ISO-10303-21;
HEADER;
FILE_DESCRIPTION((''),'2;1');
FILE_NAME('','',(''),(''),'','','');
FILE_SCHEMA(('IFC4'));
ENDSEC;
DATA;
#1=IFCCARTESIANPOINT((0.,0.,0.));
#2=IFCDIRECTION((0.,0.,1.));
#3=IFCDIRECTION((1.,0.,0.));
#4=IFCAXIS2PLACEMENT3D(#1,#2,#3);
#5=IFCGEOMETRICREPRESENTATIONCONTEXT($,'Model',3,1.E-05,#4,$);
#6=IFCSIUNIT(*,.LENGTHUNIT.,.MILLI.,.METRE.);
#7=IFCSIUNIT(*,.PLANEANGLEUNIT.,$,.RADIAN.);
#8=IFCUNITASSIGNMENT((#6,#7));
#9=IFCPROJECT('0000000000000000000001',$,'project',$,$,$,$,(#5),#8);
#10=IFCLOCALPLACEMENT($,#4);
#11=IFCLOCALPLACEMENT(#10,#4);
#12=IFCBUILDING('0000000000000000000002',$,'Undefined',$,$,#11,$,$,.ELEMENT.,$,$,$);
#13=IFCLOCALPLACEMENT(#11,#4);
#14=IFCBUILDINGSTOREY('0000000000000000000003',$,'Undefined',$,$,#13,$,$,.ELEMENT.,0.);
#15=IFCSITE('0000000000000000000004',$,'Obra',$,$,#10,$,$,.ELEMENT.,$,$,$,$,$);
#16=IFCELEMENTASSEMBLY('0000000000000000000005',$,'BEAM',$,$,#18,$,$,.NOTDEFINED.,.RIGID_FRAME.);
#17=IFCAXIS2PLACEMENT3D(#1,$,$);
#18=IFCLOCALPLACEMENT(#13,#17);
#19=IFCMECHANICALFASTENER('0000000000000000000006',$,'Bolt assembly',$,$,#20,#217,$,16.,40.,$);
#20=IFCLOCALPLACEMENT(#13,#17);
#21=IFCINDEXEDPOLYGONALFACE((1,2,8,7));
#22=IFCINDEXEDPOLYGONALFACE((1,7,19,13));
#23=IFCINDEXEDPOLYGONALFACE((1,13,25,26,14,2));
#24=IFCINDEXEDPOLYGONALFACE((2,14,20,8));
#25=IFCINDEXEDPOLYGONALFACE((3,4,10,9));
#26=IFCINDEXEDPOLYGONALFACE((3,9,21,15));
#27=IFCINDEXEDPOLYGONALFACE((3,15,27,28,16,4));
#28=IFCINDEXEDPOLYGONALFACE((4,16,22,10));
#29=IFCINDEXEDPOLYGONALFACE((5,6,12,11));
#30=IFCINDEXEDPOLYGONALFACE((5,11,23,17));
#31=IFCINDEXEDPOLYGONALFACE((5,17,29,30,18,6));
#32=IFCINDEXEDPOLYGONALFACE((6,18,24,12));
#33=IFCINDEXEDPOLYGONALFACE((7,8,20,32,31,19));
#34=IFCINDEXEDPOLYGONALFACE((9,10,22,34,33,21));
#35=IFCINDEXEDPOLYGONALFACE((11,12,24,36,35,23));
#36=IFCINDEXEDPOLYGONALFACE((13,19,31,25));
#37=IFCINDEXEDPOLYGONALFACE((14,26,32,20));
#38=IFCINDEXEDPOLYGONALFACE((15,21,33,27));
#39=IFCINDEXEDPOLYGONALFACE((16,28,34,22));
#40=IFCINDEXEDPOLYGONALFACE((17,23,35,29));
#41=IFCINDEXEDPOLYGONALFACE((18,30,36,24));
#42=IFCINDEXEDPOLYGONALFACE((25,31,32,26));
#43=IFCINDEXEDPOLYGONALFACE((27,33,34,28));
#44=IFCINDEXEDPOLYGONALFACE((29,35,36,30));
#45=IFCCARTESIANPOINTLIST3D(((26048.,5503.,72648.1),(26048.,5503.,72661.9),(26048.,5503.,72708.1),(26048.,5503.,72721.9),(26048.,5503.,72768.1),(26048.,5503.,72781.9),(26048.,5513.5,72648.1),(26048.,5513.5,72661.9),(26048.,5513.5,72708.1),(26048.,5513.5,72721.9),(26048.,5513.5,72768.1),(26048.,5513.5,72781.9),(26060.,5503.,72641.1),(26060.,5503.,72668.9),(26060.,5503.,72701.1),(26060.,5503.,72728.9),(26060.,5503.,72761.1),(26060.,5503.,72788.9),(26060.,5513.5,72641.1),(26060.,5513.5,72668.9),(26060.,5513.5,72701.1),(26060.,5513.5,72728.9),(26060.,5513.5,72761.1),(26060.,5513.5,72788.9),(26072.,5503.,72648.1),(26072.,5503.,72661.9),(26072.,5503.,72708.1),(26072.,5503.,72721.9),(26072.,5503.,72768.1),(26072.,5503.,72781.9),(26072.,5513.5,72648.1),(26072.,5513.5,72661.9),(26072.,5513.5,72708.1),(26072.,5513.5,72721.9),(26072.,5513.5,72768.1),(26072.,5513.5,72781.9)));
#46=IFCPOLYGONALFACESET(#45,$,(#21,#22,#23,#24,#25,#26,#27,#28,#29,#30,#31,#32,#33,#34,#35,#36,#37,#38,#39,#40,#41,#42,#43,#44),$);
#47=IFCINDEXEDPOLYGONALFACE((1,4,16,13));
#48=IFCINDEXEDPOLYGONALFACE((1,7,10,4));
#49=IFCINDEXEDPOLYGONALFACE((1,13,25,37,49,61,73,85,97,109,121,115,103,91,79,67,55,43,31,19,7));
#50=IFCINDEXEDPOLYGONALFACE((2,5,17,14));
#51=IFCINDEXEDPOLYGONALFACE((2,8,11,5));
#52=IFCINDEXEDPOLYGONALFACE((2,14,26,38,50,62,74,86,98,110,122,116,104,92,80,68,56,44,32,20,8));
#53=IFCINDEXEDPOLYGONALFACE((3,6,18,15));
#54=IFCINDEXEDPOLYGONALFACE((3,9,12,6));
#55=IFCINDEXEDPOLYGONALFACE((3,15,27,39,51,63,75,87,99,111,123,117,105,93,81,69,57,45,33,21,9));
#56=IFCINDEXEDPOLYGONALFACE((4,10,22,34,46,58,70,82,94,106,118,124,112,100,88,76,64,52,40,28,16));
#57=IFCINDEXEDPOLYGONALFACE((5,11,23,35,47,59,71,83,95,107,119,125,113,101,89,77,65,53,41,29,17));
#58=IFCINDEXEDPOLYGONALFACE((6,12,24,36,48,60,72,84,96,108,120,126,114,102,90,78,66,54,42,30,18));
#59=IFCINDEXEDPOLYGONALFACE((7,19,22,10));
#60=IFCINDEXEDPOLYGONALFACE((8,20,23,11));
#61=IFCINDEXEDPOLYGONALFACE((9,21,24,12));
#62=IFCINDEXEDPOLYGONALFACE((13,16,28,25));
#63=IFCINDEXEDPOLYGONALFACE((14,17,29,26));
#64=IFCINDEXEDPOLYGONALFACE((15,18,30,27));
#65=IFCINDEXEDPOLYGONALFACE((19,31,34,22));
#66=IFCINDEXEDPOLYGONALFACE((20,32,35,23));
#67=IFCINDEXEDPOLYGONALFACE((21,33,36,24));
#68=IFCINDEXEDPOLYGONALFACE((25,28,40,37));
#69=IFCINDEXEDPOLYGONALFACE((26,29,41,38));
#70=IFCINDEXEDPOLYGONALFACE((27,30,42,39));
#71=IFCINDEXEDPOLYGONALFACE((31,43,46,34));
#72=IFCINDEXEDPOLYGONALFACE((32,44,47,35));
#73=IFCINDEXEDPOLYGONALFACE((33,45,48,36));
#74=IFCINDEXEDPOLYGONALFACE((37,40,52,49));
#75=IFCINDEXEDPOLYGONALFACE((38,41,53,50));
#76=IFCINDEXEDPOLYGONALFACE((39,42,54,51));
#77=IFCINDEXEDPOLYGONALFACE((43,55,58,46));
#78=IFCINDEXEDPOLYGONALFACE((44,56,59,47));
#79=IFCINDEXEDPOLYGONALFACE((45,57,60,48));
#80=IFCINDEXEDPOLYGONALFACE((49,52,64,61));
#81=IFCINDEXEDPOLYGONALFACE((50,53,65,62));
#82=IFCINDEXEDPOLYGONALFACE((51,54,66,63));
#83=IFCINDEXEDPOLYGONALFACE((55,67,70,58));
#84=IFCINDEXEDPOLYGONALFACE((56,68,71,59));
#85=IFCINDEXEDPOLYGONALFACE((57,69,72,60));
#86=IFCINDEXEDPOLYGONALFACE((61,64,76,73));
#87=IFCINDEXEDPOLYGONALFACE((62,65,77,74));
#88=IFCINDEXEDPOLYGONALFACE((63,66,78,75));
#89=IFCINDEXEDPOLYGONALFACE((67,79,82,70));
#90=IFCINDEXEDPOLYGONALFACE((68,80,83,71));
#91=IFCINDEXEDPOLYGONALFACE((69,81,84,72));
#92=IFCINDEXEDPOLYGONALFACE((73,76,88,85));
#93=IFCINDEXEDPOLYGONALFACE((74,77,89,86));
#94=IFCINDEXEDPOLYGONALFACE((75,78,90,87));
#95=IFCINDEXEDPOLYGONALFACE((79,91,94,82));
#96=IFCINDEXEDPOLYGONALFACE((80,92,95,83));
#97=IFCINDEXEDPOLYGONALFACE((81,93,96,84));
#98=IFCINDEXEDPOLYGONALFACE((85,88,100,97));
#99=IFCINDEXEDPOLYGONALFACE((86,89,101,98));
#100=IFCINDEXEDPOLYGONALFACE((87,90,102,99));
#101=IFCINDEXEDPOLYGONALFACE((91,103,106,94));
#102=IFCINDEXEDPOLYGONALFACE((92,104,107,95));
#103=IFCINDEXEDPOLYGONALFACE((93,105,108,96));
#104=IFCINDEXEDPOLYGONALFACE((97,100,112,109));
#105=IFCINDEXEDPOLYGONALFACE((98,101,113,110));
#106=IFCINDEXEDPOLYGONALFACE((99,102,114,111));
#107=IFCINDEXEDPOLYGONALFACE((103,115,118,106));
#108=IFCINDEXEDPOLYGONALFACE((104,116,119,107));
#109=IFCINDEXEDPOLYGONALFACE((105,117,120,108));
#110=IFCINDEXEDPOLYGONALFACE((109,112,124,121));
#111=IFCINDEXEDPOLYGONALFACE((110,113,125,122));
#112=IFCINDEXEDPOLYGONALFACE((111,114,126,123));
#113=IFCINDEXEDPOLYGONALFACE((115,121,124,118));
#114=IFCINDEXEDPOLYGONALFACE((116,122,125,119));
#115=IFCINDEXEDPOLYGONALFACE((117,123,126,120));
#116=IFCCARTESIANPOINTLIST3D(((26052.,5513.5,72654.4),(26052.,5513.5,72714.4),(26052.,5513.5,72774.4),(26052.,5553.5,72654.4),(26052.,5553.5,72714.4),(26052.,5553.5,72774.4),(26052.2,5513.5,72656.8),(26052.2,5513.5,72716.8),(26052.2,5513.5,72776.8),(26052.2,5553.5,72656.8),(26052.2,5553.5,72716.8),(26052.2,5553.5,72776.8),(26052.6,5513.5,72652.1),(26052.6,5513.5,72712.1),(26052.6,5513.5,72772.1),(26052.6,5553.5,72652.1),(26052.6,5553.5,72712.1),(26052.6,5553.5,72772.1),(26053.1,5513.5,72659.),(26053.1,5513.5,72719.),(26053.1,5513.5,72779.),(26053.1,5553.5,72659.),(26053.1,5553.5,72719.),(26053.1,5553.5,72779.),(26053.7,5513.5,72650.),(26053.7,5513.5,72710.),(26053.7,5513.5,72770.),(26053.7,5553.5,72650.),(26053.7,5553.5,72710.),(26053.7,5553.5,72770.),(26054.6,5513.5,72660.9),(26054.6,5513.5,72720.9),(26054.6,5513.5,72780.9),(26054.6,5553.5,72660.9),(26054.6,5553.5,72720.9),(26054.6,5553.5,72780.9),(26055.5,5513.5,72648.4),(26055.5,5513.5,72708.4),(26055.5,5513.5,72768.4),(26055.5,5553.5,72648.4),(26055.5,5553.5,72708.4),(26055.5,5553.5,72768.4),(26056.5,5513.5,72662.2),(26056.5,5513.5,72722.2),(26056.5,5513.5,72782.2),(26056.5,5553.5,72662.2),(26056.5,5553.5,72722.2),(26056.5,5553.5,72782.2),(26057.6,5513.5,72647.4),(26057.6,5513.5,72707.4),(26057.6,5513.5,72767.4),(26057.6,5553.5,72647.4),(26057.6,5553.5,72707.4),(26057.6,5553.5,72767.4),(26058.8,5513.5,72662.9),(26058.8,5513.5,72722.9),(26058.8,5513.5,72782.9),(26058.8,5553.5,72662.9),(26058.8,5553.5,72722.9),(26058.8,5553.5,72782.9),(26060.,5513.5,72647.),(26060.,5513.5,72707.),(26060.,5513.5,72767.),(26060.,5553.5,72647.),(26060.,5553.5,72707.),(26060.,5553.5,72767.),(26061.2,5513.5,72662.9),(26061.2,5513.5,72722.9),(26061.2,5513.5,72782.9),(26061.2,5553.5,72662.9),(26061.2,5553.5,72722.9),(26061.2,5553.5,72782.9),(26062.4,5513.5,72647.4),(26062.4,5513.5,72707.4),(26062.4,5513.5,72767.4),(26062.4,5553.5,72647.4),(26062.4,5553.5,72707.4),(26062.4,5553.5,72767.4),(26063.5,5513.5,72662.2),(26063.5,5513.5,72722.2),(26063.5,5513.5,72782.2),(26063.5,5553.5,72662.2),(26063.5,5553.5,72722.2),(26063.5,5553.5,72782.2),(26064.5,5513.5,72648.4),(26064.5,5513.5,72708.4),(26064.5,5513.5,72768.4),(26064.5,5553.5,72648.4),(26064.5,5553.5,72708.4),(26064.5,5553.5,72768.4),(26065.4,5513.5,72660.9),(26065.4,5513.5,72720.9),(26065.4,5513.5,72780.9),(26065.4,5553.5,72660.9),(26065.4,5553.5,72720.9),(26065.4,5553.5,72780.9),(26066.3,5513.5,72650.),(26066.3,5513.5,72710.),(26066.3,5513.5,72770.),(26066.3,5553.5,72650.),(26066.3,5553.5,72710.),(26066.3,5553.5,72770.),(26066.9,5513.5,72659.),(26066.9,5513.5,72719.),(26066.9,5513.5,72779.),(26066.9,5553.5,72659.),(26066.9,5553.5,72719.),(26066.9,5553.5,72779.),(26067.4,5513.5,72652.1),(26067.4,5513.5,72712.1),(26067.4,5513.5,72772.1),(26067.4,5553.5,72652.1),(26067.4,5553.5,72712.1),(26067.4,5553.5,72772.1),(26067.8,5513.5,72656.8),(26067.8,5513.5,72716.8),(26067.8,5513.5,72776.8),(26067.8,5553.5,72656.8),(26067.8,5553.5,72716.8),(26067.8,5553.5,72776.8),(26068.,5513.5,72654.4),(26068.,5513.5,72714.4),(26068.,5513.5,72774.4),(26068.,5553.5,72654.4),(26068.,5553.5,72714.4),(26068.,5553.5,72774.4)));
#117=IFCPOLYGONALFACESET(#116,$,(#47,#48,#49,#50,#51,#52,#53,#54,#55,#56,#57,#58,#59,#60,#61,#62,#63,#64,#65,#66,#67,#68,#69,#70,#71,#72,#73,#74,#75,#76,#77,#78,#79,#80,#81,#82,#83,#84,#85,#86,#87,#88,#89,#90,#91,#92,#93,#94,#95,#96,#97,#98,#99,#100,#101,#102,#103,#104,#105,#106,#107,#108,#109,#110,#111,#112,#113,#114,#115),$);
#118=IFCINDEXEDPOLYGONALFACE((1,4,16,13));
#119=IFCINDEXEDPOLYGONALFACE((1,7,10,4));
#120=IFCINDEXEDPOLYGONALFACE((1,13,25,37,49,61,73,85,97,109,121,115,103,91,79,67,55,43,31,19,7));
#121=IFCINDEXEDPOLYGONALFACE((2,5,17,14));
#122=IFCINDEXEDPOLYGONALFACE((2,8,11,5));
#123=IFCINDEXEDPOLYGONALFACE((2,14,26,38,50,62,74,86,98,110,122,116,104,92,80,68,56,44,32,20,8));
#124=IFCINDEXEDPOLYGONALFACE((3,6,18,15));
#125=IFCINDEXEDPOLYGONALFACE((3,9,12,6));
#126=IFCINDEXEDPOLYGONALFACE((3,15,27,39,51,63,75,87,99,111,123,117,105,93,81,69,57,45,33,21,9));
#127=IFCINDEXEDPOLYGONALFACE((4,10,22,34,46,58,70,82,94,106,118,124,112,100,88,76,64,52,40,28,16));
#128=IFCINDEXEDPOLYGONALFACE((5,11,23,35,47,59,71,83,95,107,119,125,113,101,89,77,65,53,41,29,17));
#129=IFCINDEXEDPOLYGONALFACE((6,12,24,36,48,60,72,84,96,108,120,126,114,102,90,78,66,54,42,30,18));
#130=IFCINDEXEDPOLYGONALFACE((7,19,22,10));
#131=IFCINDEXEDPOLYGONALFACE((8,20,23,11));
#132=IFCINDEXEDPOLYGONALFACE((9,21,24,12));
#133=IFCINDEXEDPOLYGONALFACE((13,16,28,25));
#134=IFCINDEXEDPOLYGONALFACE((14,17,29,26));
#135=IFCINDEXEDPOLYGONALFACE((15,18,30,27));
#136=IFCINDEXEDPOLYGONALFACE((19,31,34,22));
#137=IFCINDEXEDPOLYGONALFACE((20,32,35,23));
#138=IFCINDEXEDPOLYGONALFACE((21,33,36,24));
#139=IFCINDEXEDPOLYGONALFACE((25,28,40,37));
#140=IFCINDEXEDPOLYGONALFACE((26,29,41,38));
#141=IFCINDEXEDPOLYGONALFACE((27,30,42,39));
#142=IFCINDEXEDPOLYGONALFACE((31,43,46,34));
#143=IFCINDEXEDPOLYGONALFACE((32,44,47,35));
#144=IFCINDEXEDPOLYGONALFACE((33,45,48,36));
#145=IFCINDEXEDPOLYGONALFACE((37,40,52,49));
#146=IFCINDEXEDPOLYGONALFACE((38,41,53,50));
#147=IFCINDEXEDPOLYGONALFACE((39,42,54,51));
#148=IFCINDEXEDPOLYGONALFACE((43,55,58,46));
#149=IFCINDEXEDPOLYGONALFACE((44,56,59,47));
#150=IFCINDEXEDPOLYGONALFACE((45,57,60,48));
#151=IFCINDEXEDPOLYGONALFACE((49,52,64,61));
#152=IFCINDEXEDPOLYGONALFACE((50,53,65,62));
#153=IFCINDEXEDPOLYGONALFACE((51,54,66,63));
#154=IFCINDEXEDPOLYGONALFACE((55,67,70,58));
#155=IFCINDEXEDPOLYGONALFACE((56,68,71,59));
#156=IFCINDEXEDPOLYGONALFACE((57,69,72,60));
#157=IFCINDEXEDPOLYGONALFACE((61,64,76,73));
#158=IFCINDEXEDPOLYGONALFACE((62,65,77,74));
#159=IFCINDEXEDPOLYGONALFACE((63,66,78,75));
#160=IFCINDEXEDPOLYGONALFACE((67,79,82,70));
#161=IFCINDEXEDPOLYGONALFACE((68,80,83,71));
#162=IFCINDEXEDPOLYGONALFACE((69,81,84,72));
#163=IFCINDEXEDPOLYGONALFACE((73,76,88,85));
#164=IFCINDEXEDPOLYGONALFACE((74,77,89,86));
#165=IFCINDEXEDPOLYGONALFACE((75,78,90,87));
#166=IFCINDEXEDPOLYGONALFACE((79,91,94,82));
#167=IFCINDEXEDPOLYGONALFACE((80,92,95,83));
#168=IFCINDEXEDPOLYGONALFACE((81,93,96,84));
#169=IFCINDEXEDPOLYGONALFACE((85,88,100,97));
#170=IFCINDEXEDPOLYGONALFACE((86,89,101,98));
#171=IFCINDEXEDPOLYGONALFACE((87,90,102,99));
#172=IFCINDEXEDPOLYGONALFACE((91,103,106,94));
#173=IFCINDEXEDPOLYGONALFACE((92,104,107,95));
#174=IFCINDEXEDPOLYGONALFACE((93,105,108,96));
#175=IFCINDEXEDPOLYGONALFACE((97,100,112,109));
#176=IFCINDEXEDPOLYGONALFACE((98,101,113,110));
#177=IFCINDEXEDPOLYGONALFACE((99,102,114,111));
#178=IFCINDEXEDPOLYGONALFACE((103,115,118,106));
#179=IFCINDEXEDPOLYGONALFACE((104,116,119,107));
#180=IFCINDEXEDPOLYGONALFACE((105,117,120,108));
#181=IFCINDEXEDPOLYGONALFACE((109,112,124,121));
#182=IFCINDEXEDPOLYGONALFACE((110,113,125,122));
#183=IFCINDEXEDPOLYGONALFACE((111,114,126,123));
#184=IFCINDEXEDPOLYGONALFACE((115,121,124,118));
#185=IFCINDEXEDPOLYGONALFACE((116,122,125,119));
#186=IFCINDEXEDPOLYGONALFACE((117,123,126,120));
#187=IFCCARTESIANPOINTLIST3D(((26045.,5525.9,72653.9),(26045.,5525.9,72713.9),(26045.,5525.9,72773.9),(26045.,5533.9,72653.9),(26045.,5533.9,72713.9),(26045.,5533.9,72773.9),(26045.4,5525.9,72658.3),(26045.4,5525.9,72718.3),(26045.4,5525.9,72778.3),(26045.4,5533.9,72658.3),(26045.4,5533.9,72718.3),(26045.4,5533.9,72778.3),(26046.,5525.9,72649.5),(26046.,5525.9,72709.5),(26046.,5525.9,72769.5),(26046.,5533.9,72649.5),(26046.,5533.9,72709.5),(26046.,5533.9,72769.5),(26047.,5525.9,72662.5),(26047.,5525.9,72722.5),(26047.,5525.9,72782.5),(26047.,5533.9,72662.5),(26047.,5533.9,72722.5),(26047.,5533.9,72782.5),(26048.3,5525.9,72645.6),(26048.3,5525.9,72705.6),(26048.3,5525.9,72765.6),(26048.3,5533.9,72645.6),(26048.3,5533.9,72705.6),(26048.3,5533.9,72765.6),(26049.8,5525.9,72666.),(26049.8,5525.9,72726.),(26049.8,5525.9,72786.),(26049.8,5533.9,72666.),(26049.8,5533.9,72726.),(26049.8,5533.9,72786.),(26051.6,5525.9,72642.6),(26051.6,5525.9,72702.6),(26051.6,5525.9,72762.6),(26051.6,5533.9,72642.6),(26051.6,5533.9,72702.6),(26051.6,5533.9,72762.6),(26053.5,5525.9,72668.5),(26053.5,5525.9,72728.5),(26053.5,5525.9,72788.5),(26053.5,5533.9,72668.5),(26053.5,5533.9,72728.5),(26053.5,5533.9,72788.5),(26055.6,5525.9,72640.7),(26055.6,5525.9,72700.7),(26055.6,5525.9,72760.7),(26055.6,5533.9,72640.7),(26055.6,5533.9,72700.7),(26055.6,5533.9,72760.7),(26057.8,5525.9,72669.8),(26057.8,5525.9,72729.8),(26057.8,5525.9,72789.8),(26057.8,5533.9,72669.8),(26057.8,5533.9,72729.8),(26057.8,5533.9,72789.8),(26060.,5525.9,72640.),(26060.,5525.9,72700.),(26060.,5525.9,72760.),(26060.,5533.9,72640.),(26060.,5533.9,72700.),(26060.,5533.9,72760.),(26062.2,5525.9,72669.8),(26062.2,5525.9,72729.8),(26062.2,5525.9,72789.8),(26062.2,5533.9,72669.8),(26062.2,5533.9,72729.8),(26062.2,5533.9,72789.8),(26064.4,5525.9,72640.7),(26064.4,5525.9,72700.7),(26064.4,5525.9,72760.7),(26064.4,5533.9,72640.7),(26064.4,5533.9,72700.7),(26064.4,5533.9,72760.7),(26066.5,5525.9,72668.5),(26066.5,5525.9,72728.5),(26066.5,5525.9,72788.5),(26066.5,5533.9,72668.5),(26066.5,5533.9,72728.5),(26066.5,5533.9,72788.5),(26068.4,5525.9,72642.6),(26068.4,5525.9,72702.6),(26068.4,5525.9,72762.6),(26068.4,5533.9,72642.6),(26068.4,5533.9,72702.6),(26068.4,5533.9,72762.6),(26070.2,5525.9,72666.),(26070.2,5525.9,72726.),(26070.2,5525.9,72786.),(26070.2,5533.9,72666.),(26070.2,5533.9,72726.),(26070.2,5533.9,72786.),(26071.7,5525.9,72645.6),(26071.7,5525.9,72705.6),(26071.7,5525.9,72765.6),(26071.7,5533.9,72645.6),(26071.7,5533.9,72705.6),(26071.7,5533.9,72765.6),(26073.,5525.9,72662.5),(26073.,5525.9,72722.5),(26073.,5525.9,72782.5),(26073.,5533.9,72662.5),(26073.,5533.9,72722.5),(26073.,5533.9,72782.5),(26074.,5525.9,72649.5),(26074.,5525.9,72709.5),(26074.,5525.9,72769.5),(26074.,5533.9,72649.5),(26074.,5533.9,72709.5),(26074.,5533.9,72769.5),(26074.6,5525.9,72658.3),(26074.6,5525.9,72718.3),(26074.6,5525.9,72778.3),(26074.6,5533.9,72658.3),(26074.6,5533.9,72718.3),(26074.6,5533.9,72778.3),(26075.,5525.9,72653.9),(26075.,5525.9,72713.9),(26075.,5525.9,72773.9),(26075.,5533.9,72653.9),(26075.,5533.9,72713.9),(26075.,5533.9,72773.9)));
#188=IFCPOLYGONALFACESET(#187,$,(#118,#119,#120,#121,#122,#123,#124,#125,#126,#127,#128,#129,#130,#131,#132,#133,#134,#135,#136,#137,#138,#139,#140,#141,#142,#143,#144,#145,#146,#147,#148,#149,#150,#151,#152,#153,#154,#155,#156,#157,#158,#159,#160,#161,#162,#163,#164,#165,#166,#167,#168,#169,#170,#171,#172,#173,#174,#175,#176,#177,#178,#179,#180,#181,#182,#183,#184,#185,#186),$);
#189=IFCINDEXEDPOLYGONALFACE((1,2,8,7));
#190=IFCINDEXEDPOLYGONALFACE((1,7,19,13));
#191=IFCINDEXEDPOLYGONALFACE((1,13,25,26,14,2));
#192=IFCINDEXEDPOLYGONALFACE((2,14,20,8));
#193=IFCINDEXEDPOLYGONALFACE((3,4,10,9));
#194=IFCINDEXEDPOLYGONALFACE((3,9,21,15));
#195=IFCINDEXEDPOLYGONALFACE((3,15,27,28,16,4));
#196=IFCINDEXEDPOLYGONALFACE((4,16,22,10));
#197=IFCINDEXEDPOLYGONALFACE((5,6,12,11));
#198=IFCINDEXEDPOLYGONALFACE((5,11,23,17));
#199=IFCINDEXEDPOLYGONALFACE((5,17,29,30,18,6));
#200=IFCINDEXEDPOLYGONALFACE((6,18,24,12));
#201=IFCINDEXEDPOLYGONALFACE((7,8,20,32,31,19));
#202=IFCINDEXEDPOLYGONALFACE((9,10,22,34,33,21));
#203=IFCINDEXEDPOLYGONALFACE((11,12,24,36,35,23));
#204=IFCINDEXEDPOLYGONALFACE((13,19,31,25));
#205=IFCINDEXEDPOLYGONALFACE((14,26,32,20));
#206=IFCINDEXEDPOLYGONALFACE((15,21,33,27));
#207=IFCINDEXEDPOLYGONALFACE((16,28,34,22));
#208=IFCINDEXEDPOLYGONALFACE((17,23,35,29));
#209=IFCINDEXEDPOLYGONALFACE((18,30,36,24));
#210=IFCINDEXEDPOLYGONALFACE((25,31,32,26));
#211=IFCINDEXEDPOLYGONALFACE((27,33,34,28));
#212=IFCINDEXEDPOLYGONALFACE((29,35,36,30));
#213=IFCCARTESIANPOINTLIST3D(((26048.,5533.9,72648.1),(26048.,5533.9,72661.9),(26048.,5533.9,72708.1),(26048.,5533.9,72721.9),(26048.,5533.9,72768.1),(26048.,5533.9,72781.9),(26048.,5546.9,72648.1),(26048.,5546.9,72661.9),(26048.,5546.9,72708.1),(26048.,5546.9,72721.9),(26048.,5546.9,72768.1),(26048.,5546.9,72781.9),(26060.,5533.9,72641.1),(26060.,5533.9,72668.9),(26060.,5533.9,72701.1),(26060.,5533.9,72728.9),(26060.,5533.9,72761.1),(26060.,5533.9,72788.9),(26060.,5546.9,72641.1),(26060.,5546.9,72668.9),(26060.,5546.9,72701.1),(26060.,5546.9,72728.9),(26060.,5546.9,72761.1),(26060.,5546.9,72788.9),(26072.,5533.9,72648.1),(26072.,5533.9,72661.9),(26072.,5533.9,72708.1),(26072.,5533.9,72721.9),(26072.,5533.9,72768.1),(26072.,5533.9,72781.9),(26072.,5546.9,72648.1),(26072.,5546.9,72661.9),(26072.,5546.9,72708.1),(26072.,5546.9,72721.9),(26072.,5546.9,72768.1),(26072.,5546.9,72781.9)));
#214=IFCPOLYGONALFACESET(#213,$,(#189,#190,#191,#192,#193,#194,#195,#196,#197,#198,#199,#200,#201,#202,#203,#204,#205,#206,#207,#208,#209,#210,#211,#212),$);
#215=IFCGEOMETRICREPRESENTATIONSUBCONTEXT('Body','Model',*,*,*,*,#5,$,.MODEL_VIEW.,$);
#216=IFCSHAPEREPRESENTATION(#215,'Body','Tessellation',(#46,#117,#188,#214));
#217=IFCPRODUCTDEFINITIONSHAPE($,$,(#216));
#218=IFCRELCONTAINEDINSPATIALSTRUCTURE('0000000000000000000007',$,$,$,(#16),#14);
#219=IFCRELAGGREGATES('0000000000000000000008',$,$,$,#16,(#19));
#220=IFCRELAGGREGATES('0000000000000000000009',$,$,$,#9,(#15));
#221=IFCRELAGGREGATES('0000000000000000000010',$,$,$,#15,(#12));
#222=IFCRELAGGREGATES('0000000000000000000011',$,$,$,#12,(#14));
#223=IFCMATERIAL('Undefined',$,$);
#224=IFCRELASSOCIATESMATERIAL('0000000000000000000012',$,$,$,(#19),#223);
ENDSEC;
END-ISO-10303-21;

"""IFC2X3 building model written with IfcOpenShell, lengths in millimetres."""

from ifc_helpers import new_model, si_unit, frame, origin_with_axes, origin_2d_with_axis, place, context, subcontext, project, spatial, polyline, circle, outline, extrude, source, transform, mapped, material, element, aggregate, save


model = new_model("IFC2X3")

# Units and contexts
model_context = context("Model", 3, precision=1e-05, world=origin_with_axes())
body_context = subcontext(model_context, "Body", "Model", "MODEL_VIEW")
ifc_project = project(units=[si_unit("LENGTHUNIT", "METRE", prefix="MILLI"), si_unit("PLANEANGLEUNIT", "RADIAN")], contexts=[model_context])

# Site, building, storey
site_placement = place(None, origin_with_axes())
site = spatial("IfcSite", under=ifc_project, at=site_placement, Name="Obra", CompositionType="ELEMENT")
building_placement = place(site_placement, origin_with_axes())
building = spatial("IfcBuilding", under=site, at=building_placement, Name="Undefined", CompositionType="ELEMENT")
storey_placement = place(building_placement, origin_with_axes())
storey = spatial("IfcBuildingStorey", under=building, at=storey_placement, Name="Undefined", CompositionType="ELEMENT", Elevation=0.0)

# Shared definitions
ifc_material = material(Name="Undefined")

# Element assembly, mechanical fastener
assembly_1_placement = place(storey_placement, origin_with_axes())
assembly_1 = element("IfcElementAssembly", 1, at=assembly_1_placement, inside=storey, Name="BEAM", AssemblyPlace="NOTDEFINED", PredefinedType="RIGID_FRAME")
shared_shape_1 = source(origin_with_axes(), body_context, "Body", "SweptSolid", [
    extrude(outline(polyline([(13.9, 0.0), (6.9, 12.0), (-6.9, 12.0), (-13.9, 0.0), (-6.9, -12.0), (6.9, -12.0), (13.9, 0.0)])), frame((0.0, -19.7, 0.0), z_axis=(0.0, 1.0, 0.0), x_axis=(1.0, 0.0, 0.0)), (0.0, 0.0, 1.0), 10.6),
    extrude(circle(Radius=8.0, at=origin_2d_with_axis()), frame((0.0, -9.1, 0.0), z_axis=(0.0, 1.0, 0.0), x_axis=(1.0, 0.0, 0.0)), (0.0, 0.0, 1.0), 40.0),
    extrude(circle(Radius=15.0, at=origin_2d_with_axis()), frame((0.0, 3.3, 0.0), z_axis=(0.0, 1.0, 0.0), x_axis=(1.0, 0.0, 0.0)), (0.0, 0.0, 1.0), 8.0),
    extrude(outline(polyline([(13.9, 0.0), (6.9, 12.0), (-6.9, 12.0), (-13.9, 0.0), (-6.9, -12.0), (6.9, -12.0), (13.9, 0.0)])), frame((0.0, 11.3, 0.0), z_axis=(0.0, 1.0, 0.0), x_axis=(1.0, 0.0, 0.0)), (0.0, 0.0, 1.0), 13.0),
])
mechanical_fastener_1_placement = place(assembly_1_placement, frame((26010.0, 5522.6, 72835.0), z_axis=(1.0, 0.0, 0.0), x_axis=(0.0, 0.0, -1.0)))
mechanical_fastener_1 = element("IfcMechanicalFastener", 2, at=mechanical_fastener_1_placement, material=ifc_material, Name="Bolt assembly", NominalDiameter=16.0, NominalLength=40.0, context=body_context, shape_type="MappedRepresentation", body=[
    mapped(shared_shape_1, transform((60.0, 0.0, 50.0))),
    mapped(shared_shape_1, transform((120.0, 0.0, 50.0))),
    mapped(shared_shape_1, transform((180.0, 0.0, 50.0))),
])
aggregate(assembly_1, [mechanical_fastener_1])

save(model, "model.ifc")
